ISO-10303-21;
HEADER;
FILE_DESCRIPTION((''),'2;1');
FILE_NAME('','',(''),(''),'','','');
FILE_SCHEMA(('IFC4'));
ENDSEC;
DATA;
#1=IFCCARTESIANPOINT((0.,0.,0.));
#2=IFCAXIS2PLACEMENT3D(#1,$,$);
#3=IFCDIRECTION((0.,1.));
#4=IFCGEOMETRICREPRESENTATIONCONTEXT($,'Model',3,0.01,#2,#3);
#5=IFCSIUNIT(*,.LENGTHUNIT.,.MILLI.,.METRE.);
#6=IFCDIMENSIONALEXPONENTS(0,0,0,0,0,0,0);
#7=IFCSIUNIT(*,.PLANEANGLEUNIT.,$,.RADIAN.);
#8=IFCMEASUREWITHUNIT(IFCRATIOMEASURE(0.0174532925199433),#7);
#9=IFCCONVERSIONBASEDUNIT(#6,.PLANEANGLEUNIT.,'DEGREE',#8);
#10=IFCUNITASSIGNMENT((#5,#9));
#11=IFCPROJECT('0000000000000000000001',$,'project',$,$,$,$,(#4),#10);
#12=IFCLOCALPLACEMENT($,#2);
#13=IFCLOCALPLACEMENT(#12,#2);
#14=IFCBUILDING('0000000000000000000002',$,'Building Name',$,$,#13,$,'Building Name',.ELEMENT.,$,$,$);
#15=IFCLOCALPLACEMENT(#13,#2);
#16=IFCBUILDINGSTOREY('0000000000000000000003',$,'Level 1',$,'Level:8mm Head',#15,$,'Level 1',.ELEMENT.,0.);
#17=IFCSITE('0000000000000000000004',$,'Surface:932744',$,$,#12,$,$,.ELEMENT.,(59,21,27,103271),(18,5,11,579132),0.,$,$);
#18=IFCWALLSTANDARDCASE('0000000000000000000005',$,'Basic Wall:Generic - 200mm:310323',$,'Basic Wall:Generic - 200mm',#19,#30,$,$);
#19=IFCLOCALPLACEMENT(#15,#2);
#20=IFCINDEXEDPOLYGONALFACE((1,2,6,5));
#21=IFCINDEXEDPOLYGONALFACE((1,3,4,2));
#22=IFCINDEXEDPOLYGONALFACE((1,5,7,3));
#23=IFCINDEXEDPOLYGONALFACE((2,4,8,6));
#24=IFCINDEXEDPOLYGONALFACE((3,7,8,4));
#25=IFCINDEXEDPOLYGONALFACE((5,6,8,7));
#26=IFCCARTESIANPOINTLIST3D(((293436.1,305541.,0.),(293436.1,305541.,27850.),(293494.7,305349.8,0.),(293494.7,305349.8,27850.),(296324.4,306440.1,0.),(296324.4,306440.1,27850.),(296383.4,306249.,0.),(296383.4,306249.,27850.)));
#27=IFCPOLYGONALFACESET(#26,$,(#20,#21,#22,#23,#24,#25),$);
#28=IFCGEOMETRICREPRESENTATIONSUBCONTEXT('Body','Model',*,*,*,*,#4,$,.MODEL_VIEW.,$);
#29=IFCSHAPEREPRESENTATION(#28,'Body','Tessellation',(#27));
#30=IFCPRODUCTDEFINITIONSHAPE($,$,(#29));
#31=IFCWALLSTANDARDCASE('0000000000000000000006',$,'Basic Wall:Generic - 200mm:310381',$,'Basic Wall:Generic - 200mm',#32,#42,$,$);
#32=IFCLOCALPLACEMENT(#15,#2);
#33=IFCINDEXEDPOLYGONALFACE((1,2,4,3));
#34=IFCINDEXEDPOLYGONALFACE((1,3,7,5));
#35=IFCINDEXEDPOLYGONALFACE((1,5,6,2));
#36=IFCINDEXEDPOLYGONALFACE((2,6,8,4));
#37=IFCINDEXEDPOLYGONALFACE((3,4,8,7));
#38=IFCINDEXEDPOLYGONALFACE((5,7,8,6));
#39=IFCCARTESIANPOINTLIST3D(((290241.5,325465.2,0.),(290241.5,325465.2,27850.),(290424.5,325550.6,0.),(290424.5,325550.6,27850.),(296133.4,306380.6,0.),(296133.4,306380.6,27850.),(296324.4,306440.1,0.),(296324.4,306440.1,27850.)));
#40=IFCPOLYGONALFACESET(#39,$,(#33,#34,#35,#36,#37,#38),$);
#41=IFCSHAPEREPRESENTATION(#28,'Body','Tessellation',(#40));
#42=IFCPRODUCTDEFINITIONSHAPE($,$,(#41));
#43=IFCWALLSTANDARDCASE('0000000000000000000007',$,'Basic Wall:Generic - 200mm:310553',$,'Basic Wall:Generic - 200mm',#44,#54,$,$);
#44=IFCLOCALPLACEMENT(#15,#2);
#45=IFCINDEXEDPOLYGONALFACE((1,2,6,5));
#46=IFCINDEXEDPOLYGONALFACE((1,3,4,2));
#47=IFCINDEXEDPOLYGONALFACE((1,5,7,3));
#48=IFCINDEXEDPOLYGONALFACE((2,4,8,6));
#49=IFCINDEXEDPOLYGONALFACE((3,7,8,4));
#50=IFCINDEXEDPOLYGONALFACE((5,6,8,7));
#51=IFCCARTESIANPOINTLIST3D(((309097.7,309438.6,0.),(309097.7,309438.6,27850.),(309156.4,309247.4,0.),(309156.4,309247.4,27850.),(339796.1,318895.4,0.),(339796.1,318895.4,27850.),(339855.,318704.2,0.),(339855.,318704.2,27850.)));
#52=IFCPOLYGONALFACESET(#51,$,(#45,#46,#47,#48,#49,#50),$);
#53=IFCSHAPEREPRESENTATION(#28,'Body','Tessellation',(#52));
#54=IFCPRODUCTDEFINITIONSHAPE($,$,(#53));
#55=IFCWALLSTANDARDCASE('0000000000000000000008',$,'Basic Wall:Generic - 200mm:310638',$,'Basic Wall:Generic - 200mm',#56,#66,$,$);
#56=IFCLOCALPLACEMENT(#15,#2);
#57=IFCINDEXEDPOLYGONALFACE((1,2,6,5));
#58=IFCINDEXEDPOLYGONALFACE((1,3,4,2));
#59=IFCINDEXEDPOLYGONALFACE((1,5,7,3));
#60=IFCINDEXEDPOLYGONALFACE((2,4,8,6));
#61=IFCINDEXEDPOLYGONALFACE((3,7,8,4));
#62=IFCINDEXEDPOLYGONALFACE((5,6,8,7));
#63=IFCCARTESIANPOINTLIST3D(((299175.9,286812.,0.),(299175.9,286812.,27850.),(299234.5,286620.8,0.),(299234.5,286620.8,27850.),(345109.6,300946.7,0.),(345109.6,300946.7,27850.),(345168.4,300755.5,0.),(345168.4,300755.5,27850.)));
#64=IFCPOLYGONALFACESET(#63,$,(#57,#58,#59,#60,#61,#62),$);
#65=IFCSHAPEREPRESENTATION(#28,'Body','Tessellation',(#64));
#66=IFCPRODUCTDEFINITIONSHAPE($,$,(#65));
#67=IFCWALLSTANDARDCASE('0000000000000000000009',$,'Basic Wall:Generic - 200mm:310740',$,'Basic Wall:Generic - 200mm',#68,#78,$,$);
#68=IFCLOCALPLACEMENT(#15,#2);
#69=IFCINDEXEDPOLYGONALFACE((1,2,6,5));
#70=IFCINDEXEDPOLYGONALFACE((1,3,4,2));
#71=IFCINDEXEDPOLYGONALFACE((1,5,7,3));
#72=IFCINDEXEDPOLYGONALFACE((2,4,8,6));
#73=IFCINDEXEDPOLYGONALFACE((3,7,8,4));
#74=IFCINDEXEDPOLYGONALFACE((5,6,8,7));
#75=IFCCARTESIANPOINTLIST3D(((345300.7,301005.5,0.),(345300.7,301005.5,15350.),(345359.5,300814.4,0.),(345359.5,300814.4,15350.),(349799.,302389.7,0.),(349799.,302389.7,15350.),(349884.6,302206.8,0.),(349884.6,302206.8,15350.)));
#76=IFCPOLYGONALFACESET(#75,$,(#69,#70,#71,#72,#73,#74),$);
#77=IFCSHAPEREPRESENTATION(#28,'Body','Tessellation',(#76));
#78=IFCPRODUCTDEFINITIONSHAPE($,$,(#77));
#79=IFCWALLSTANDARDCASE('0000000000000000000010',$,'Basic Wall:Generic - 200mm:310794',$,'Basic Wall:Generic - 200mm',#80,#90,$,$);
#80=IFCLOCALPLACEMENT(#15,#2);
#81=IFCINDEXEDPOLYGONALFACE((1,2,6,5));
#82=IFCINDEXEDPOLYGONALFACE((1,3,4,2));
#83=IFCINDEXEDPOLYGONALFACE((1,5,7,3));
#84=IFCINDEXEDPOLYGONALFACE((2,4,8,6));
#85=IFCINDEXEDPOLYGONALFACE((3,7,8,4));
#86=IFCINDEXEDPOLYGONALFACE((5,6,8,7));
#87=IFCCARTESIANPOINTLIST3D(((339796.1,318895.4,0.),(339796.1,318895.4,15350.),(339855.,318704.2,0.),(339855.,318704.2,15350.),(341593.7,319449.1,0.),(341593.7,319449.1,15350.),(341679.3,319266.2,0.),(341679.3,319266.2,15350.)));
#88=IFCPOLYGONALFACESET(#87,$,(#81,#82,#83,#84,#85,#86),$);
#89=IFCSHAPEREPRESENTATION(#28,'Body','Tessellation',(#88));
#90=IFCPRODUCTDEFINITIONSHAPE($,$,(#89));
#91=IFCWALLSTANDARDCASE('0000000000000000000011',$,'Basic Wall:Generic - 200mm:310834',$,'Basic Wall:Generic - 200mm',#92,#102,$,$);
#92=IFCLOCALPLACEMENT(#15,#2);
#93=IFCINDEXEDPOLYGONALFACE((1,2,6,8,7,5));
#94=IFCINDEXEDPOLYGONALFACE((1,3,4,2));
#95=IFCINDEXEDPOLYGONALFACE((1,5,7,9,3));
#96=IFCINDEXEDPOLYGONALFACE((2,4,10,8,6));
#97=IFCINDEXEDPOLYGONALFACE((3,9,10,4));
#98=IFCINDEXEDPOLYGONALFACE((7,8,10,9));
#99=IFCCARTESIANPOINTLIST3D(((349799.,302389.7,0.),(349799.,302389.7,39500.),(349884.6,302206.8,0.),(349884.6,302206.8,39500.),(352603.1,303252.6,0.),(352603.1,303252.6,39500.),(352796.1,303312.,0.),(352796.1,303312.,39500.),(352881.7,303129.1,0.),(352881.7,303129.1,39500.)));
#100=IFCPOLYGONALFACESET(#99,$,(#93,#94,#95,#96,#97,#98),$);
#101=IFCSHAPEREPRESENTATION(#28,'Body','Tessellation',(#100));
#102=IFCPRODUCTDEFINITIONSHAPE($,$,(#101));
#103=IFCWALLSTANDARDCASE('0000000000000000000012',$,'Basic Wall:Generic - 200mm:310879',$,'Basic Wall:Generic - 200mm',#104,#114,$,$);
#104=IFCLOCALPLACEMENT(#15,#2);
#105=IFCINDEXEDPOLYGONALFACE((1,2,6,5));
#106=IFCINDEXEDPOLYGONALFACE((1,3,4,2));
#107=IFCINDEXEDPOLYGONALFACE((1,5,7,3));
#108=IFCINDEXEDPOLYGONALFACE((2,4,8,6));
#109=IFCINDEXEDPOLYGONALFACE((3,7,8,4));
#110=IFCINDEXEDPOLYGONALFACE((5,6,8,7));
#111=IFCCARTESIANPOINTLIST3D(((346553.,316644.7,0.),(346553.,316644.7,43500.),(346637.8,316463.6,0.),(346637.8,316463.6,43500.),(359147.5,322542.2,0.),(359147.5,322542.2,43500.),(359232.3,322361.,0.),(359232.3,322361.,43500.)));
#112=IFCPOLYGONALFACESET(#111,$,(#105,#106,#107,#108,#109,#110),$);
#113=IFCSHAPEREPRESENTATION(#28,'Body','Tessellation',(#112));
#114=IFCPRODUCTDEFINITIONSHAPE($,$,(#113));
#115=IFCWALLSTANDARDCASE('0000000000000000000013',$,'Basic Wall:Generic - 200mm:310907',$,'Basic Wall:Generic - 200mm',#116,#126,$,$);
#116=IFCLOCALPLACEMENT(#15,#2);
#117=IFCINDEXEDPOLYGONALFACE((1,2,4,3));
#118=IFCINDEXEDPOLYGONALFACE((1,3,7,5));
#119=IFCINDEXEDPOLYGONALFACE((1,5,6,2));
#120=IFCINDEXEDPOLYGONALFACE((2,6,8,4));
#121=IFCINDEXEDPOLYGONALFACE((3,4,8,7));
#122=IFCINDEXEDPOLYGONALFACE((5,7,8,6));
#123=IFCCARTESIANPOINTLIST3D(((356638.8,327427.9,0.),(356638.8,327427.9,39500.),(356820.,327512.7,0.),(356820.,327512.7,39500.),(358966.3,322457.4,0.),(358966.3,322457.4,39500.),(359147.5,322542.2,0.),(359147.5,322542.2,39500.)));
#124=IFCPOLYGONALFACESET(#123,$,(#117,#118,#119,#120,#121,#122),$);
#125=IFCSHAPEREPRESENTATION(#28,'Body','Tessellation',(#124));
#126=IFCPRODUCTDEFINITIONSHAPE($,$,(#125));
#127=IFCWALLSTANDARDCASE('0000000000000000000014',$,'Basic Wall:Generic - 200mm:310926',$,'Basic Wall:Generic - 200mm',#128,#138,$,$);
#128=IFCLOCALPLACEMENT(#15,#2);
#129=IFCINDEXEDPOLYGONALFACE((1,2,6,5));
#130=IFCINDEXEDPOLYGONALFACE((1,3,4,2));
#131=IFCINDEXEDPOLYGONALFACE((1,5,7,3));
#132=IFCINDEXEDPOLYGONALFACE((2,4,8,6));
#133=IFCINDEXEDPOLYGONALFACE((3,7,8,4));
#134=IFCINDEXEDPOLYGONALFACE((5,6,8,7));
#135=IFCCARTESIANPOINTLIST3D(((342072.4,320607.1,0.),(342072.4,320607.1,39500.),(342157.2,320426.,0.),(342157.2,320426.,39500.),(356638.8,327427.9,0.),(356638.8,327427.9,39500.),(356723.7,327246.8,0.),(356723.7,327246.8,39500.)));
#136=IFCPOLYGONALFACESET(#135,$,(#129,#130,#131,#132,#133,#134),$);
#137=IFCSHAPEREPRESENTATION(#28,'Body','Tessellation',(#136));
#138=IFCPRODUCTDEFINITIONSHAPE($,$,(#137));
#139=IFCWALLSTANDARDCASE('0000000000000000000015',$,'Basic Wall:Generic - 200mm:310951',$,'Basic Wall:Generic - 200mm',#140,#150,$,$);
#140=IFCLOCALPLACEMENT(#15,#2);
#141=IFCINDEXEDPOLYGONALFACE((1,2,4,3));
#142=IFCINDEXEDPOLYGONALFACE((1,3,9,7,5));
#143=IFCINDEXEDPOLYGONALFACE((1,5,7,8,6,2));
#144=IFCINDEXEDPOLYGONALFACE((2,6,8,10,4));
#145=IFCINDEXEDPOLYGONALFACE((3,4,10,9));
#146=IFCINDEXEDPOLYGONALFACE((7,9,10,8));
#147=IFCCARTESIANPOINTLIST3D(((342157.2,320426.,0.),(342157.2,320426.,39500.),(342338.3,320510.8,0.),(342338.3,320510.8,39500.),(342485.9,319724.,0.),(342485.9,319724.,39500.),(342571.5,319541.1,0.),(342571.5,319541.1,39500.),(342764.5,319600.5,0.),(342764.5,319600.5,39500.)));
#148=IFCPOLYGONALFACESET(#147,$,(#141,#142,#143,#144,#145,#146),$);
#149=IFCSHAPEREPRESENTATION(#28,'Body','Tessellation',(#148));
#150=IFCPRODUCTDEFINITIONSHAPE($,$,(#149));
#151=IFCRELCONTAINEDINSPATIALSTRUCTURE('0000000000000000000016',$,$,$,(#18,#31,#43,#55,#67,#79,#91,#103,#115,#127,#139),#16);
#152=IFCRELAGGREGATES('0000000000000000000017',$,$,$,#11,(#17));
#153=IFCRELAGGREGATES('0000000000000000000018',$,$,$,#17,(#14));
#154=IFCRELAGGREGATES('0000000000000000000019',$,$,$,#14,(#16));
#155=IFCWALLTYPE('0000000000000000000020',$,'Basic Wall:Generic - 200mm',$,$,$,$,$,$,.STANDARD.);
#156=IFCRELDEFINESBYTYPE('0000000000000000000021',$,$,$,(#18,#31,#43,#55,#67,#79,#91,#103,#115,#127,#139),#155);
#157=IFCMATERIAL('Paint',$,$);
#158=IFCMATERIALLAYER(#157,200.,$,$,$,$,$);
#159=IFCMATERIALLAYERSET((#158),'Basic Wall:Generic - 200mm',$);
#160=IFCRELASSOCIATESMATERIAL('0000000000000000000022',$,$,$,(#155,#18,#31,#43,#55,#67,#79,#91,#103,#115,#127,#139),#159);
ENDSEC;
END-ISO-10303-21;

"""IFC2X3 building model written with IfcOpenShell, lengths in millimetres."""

from ifc_helpers import new_model, entity, si_unit, converted_unit, direction, frame, frame_2d, origin, place, context, subcontext, project, spatial, polyline, rectangle, outline, extrude, clip, bounded_halfspace, material, layer, layer_set, layer_usage, type_object, element, save


model = new_model("IFC2X3")

# Units and contexts
model_context = context("Model", 3, precision=0.01, world=origin(), true_north=direction((0.0, 1.0)))
body_context = subcontext(model_context, "Body", "Model", "MODEL_VIEW")
ifc_project = project(units=[si_unit("LENGTHUNIT", "METRE", prefix="MILLI"), converted_unit("PLANEANGLEUNIT", "DEGREE", entity("IfcRatioMeasure", 0.0174532925199433), si_unit("PLANEANGLEUNIT", "RADIAN"), dimensions=[0, 0, 0, 0, 0, 0, 0])], contexts=[model_context])

# Site, building, storey
site_placement = place(None, origin())
site = spatial("IfcSite", under=ifc_project, at=site_placement, Name="Surface:932744", CompositionType="ELEMENT", RefLatitude=(59, 21, 27, 103271), RefLongitude=(18, 5, 11, 579132), RefElevation=0.0)
building_placement = place(site_placement, origin())
building = spatial("IfcBuilding", under=site, at=building_placement, Name="Building Name", LongName="Building Name", CompositionType="ELEMENT")
storey_placement = place(building_placement, origin())
storey = spatial("IfcBuildingStorey", under=building, at=storey_placement, Name="Level 1", ObjectType="Level:8mm Head", LongName="Level 1", CompositionType="ELEMENT", Elevation=0.0)

# Walls
ifc_material_1 = material(Name="Paint")
ifc_layer_1 = layer(ifc_material_1, 200.0)
ifc_layer_set_1 = layer_set([ifc_layer_1], Name="Basic Wall:Generic - 200mm")
wall_type_1 = type_object("IfcWallType", Name="Basic Wall:Generic - 200mm", PredefinedType="STANDARD", material=ifc_layer_set_1)
ifc_layer_usage_1 = layer_usage(ifc_layer_set_1, "AXIS2", "NEGATIVE", 100.0)
wall_1_placement = place(storey_placement, frame((293465.0, 305445.3, 0.0), z_axis=(0.0, 0.0, 1.0), x_axis=(0.954812, 0.29721, 0.0)))
element("IfcWallStandardCase", 1, at=wall_1_placement, inside=storey, type_object=wall_type_1, material=ifc_layer_usage_1, Name="Basic Wall:Generic - 200mm:310323", ObjectType="Basic Wall:Generic - 200mm", context=body_context, shape_type="Clipping", body=[
    clip(extrude(outline(polyline([(3025.4, -100.0), (3025.8, 100.0), (2825.8, 100.0), (0.9, 100.0), (0.0, -100.0), (3025.4, -100.0)])), origin(), (0.0, 0.0, 1.0), 27850.0), bounded_halfspace(frame((0.0, -100.0, 27850.0), z_axis=(0.0, 0.0, -1.0), x_axis=(0.999996, -0.002939, 0.0)), True, frame((0.0, -100.0, 27850.0), z_axis=(0.0, 0.0, -1.0), x_axis=(0.999996, -0.002939, 0.0)), polyline([(0.0, 0.0), (0.3, -200.0), (2825.2, -208.3), (3025.2, -208.9), (3025.3, -8.9), (0.0, 0.0)]))),
])
ifc_layer_usage_2 = layer_usage(ifc_layer_set_1, "AXIS2", "NEGATIVE", 100.0)
wall_2_placement = place(storey_placement, frame((296229.0, 306410.1, 0.0), z_axis=(0.0, 0.0, 1.0), x_axis=(-0.294987, 0.955501, 0.0)))
element("IfcWallStandardCase", 2, at=wall_2_placement, inside=storey, type_object=wall_type_1, material=ifc_layer_usage_2, Name="Basic Wall:Generic - 200mm:310381", ObjectType="Basic Wall:Generic - 200mm", context=body_context, shape_type="Clipping", body=[
    clip(extrude(outline(polyline([(20001.0, -100.0), (19973.3, 100.0), (0.0, 100.0), (0.5, -100.0), (19799.1, -100.0), (20001.0, -100.0)])), origin(), (0.0, 0.0, 1.0), 27850.0), bounded_halfspace(frame((0.5, -100.0, 27850.0), z_axis=(0.0, 0.0, -1.0), x_axis=(-0.000612, -1.0, 0.0)), True, frame((0.5, -100.0, 27850.0), z_axis=(0.0, 0.0, -1.0), x_axis=(-0.000612, -1.0, 0.0)), polyline([(0.0, 0.0), (-200.0, 0.6), (-212.2, -19972.8), (-12.2, -20000.5), (0.0, 0.0)]))),
])
ifc_layer_usage_3 = layer_usage(ifc_layer_set_1, "AXIS2", "NEGATIVE", 100.0)
wall_3_placement = place(storey_placement, frame((309127.0, 309342.9, 0.0), z_axis=(0.0, 0.0, 1.0), x_axis=(0.955682, 0.294402, 0.0)))
element("IfcWallStandardCase", 3, at=wall_3_placement, inside=storey, type_object=wall_type_1, material=ifc_layer_usage_3, Name="Basic Wall:Generic - 200mm:310553", ObjectType="Basic Wall:Generic - 200mm", context=body_context, shape_type="Clipping", body=[
    clip(extrude(outline(polyline([(32122.1, -100.0), (32122.2, 100.0), (0.1, 100.0), (0.0, -100.0), (31922.1, -100.0), (32122.1, -100.0)])), origin(), (0.0, 0.0, 1.0), 27850.0), bounded_halfspace(frame((0.0, -100.0, 27850.0), z_axis=(0.0, 0.0, -1.0), x_axis=(1.0, 0.0, 0.0)), True, frame((0.0, -100.0, 27850.0), z_axis=(0.0, 0.0, -1.0), x_axis=(1.0, 0.0, 0.0)), polyline([(0.0, 0.0), (0.1, -200.0), (32122.2, -200.0), (32122.1, 0.0), (0.0, 0.0)]))),
])

# Walls
ifc_layer_usage_4 = layer_usage(ifc_layer_set_1, "AXIS2", "NEGATIVE", 100.0)
wall_4_placement = place(storey_placement, frame((345139.0, 300851.1, 0.0), z_axis=(0.0, 0.0, 1.0), x_axis=(-0.955771, -0.29411, 0.0)))
element("IfcWallStandardCase", 4, at=wall_4_placement, inside=storey, type_object=wall_type_1, material=ifc_layer_usage_4, Name="Basic Wall:Generic - 200mm:310638", ObjectType="Basic Wall:Generic - 200mm", context=body_context, shape_type="Clipping", body=[
    clip(extrude(outline(polyline([(48059.2, -100.0), (48059.5, 100.0), (0.0, 100.0), (0.0, -100.0), (48059.2, -100.0)])), origin(), (0.0, 0.0, 1.0), 27850.0), bounded_halfspace(frame((0.0, -100.0, 27850.0), z_axis=(0.0, 0.0, -1.0), x_axis=(-1.0, -0.000306, 0.0)), True, frame((0.0, -100.0, 27850.0), z_axis=(0.0, 0.0, -1.0), x_axis=(-1.0, -0.000306, 0.0)), polyline([(0.0, 0.0), (-0.1, 200.0), (-48059.5, 185.3), (-48059.2, -14.7), (0.0, 0.0)]))),
])
ifc_layer_usage_5 = layer_usage(ifc_layer_set_1, "AXIS2", "NEGATIVE", 100.0)
wall_5_placement = place(storey_placement, frame((349855.1, 302302.4, 0.0), z_axis=(0.0, 0.0, 1.0), x_axis=(-0.955771, -0.29411, 0.0)))
element("IfcWallStandardCase", 5, at=wall_5_placement, inside=storey, type_object=wall_type_1, material=ifc_layer_usage_5, Name="Basic Wall:Generic - 200mm:310740", ObjectType="Basic Wall:Generic - 200mm", context=body_context, shape_type="Clipping", body=[
    clip(extrude(outline(polyline([(4734.4, -100.0), (4734.4, 100.0), (0.0, 100.0), (28.0, -100.0), (230.0, -100.0), (4734.4, -100.0)])), origin(), (0.0, 0.0, 1.0), 15350.0), bounded_halfspace(frame((28.0, -100.0, 15350.0), z_axis=(0.0, 0.0, -1.0), x_axis=(-1.0, -0.000306, 0.0)), True, frame((28.0, -100.0, 15350.0), z_axis=(0.0, 0.0, -1.0), x_axis=(-1.0, -0.000306, 0.0)), polyline([(0.0, 0.0), (28.0, 200.0), (-4706.5, 198.6), (-4706.4, -1.4), (0.0, 0.0)]))),
])
ifc_layer_usage_6 = layer_usage(ifc_layer_set_1, "AXIS2", "NEGATIVE", 100.0)
wall_6_placement = place(storey_placement, frame((341649.9, 319361.8, 0.0), z_axis=(0.0, 0.0, 1.0), x_axis=(-0.955682, -0.294402, 0.0)))
element("IfcWallStandardCase", 6, at=wall_6_placement, inside=storey, type_object=wall_type_1, material=ifc_layer_usage_6, Name="Basic Wall:Generic - 200mm:310794", ObjectType="Basic Wall:Generic - 200mm", context=body_context, shape_type="Clipping", body=[
    clip(extrude(outline(polyline([(1908.9, -100.0), (1909.0, 100.0), (0.0, 100.0), (28.0, -100.0), (1908.9, -100.0)])), origin(), (0.0, 0.0, 1.0), 15350.0), bounded_halfspace(frame((28.0, -100.0, 15350.0), z_axis=(0.0, 0.0, -1.0), x_axis=(-1.0, 0.0, 0.0)), True, frame((28.0, -100.0, 15350.0), z_axis=(0.0, 0.0, -1.0), x_axis=(-1.0, 0.0, 0.0)), polyline([(0.0, 0.0), (28.0, 200.0), (-1881.0, 200.0), (-1880.9, 0.0), (0.0, 0.0)]))),
])
ifc_layer_usage_7 = layer_usage(ifc_layer_set_1, "AXIS2", "NEGATIVE", 100.0)
wall_7_placement = place(storey_placement, frame((349828.4, 302294.1, 0.0), z_axis=(0.0, 0.0, 1.0), x_axis=(0.955771, 0.29411, 0.0)))
element("IfcWallStandardCase", 7, at=wall_7_placement, inside=storey, type_object=wall_type_1, material=ifc_layer_usage_7, Name="Basic Wall:Generic - 200mm:310834", ObjectType="Basic Wall:Generic - 200mm", context=body_context, shape_type="SweptSolid", body=[
    extrude(outline(polyline([(3163.9, -100.0), (3135.8, 100.0), (2933.9, 100.0), (0.0, 100.0), (28.0, -100.0), (3163.9, -100.0)])), origin(), (0.0, 0.0, 1.0), 39500.0),
])
ifc_layer_usage_8 = layer_usage(ifc_layer_set_1, "AXIS2", "NEGATIVE", 100.0)
wall_8_placement = place(storey_placement, frame((346595.4, 316554.2, 0.0), z_axis=(0.0, 0.0, 1.0), x_axis=(0.905631, 0.424066, 0.0)))
element("IfcWallStandardCase", 8, at=wall_8_placement, inside=storey, type_object=wall_type_1, material=ifc_layer_usage_8, Name="Basic Wall:Generic - 200mm:310879", ObjectType="Basic Wall:Generic - 200mm", context=body_context, shape_type="SweptSolid", body=[
    extrude(rectangle(XDim=13906.8, YDim=200.0, at=frame_2d((6953.4, 0.0), x_axis=(-1.0, 0.0))), origin(), (0.0, 0.0, 1.0), 43500.0),
])
ifc_layer_usage_9 = layer_usage(ifc_layer_set_1, "AXIS2", "NEGATIVE", 100.0)
wall_9_placement = place(storey_placement, frame((359056.9, 322499.8, 0.0), z_axis=(0.0, 0.0, 1.0), x_axis=(-0.424066, 0.905631, 0.0)))
element("IfcWallStandardCase", 9, at=wall_9_placement, inside=storey, type_object=wall_type_1, material=ifc_layer_usage_9, Name="Basic Wall:Generic - 200mm:310907", ObjectType="Basic Wall:Generic - 200mm", context=body_context, shape_type="SweptSolid", body=[
    extrude(rectangle(XDim=5488.5, YDim=200.0, at=frame_2d((2744.3, 0.0), x_axis=(-1.0, 0.0))), origin(), (0.0, 0.0, 1.0), 39500.0),
])
ifc_layer_usage_10 = layer_usage(ifc_layer_set_1, "AXIS2", "NEGATIVE", 100.0)
wall_10_placement = place(storey_placement, frame((356681.2, 327337.4, 0.0), z_axis=(0.0, 0.0, 1.0), x_axis=(-0.905631, -0.424066, 0.0)))
element("IfcWallStandardCase", 10, at=wall_10_placement, inside=storey, type_object=wall_type_1, material=ifc_layer_usage_10, Name="Basic Wall:Generic - 200mm:310926", ObjectType="Basic Wall:Generic - 200mm", context=body_context, shape_type="SweptSolid", body=[
    extrude(rectangle(XDim=16084.3, YDim=200.0, at=frame_2d((8042.2, 0.0), x_axis=(-1.0, 0.0))), origin(), (0.0, 0.0, 1.0), 39500.0),
])
ifc_layer_usage_11 = layer_usage(ifc_layer_set_1, "AXIS2", "NEGATIVE", 100.0)
wall_11_placement = place(storey_placement, frame((342247.7, 320468.4, 0.0), z_axis=(0.0, 0.0, 1.0), x_axis=(0.424066, -0.905631, 0.0)))
element("IfcWallStandardCase", 11, at=wall_11_placement, inside=storey, type_object=wall_type_1, material=ifc_layer_usage_11, Name="Basic Wall:Generic - 200mm:310951", ObjectType="Basic Wall:Generic - 200mm", context=body_context, shape_type="SweptSolid", body=[
    extrude(outline(polyline([(977.1, -100.0), (1005.1, 100.0), (0.0, 100.0), (0.0, -100.0), (775.2, -100.0), (977.1, -100.0)])), origin(), (0.0, 0.0, 1.0), 39500.0),
])

save(model, "model.ifc")
